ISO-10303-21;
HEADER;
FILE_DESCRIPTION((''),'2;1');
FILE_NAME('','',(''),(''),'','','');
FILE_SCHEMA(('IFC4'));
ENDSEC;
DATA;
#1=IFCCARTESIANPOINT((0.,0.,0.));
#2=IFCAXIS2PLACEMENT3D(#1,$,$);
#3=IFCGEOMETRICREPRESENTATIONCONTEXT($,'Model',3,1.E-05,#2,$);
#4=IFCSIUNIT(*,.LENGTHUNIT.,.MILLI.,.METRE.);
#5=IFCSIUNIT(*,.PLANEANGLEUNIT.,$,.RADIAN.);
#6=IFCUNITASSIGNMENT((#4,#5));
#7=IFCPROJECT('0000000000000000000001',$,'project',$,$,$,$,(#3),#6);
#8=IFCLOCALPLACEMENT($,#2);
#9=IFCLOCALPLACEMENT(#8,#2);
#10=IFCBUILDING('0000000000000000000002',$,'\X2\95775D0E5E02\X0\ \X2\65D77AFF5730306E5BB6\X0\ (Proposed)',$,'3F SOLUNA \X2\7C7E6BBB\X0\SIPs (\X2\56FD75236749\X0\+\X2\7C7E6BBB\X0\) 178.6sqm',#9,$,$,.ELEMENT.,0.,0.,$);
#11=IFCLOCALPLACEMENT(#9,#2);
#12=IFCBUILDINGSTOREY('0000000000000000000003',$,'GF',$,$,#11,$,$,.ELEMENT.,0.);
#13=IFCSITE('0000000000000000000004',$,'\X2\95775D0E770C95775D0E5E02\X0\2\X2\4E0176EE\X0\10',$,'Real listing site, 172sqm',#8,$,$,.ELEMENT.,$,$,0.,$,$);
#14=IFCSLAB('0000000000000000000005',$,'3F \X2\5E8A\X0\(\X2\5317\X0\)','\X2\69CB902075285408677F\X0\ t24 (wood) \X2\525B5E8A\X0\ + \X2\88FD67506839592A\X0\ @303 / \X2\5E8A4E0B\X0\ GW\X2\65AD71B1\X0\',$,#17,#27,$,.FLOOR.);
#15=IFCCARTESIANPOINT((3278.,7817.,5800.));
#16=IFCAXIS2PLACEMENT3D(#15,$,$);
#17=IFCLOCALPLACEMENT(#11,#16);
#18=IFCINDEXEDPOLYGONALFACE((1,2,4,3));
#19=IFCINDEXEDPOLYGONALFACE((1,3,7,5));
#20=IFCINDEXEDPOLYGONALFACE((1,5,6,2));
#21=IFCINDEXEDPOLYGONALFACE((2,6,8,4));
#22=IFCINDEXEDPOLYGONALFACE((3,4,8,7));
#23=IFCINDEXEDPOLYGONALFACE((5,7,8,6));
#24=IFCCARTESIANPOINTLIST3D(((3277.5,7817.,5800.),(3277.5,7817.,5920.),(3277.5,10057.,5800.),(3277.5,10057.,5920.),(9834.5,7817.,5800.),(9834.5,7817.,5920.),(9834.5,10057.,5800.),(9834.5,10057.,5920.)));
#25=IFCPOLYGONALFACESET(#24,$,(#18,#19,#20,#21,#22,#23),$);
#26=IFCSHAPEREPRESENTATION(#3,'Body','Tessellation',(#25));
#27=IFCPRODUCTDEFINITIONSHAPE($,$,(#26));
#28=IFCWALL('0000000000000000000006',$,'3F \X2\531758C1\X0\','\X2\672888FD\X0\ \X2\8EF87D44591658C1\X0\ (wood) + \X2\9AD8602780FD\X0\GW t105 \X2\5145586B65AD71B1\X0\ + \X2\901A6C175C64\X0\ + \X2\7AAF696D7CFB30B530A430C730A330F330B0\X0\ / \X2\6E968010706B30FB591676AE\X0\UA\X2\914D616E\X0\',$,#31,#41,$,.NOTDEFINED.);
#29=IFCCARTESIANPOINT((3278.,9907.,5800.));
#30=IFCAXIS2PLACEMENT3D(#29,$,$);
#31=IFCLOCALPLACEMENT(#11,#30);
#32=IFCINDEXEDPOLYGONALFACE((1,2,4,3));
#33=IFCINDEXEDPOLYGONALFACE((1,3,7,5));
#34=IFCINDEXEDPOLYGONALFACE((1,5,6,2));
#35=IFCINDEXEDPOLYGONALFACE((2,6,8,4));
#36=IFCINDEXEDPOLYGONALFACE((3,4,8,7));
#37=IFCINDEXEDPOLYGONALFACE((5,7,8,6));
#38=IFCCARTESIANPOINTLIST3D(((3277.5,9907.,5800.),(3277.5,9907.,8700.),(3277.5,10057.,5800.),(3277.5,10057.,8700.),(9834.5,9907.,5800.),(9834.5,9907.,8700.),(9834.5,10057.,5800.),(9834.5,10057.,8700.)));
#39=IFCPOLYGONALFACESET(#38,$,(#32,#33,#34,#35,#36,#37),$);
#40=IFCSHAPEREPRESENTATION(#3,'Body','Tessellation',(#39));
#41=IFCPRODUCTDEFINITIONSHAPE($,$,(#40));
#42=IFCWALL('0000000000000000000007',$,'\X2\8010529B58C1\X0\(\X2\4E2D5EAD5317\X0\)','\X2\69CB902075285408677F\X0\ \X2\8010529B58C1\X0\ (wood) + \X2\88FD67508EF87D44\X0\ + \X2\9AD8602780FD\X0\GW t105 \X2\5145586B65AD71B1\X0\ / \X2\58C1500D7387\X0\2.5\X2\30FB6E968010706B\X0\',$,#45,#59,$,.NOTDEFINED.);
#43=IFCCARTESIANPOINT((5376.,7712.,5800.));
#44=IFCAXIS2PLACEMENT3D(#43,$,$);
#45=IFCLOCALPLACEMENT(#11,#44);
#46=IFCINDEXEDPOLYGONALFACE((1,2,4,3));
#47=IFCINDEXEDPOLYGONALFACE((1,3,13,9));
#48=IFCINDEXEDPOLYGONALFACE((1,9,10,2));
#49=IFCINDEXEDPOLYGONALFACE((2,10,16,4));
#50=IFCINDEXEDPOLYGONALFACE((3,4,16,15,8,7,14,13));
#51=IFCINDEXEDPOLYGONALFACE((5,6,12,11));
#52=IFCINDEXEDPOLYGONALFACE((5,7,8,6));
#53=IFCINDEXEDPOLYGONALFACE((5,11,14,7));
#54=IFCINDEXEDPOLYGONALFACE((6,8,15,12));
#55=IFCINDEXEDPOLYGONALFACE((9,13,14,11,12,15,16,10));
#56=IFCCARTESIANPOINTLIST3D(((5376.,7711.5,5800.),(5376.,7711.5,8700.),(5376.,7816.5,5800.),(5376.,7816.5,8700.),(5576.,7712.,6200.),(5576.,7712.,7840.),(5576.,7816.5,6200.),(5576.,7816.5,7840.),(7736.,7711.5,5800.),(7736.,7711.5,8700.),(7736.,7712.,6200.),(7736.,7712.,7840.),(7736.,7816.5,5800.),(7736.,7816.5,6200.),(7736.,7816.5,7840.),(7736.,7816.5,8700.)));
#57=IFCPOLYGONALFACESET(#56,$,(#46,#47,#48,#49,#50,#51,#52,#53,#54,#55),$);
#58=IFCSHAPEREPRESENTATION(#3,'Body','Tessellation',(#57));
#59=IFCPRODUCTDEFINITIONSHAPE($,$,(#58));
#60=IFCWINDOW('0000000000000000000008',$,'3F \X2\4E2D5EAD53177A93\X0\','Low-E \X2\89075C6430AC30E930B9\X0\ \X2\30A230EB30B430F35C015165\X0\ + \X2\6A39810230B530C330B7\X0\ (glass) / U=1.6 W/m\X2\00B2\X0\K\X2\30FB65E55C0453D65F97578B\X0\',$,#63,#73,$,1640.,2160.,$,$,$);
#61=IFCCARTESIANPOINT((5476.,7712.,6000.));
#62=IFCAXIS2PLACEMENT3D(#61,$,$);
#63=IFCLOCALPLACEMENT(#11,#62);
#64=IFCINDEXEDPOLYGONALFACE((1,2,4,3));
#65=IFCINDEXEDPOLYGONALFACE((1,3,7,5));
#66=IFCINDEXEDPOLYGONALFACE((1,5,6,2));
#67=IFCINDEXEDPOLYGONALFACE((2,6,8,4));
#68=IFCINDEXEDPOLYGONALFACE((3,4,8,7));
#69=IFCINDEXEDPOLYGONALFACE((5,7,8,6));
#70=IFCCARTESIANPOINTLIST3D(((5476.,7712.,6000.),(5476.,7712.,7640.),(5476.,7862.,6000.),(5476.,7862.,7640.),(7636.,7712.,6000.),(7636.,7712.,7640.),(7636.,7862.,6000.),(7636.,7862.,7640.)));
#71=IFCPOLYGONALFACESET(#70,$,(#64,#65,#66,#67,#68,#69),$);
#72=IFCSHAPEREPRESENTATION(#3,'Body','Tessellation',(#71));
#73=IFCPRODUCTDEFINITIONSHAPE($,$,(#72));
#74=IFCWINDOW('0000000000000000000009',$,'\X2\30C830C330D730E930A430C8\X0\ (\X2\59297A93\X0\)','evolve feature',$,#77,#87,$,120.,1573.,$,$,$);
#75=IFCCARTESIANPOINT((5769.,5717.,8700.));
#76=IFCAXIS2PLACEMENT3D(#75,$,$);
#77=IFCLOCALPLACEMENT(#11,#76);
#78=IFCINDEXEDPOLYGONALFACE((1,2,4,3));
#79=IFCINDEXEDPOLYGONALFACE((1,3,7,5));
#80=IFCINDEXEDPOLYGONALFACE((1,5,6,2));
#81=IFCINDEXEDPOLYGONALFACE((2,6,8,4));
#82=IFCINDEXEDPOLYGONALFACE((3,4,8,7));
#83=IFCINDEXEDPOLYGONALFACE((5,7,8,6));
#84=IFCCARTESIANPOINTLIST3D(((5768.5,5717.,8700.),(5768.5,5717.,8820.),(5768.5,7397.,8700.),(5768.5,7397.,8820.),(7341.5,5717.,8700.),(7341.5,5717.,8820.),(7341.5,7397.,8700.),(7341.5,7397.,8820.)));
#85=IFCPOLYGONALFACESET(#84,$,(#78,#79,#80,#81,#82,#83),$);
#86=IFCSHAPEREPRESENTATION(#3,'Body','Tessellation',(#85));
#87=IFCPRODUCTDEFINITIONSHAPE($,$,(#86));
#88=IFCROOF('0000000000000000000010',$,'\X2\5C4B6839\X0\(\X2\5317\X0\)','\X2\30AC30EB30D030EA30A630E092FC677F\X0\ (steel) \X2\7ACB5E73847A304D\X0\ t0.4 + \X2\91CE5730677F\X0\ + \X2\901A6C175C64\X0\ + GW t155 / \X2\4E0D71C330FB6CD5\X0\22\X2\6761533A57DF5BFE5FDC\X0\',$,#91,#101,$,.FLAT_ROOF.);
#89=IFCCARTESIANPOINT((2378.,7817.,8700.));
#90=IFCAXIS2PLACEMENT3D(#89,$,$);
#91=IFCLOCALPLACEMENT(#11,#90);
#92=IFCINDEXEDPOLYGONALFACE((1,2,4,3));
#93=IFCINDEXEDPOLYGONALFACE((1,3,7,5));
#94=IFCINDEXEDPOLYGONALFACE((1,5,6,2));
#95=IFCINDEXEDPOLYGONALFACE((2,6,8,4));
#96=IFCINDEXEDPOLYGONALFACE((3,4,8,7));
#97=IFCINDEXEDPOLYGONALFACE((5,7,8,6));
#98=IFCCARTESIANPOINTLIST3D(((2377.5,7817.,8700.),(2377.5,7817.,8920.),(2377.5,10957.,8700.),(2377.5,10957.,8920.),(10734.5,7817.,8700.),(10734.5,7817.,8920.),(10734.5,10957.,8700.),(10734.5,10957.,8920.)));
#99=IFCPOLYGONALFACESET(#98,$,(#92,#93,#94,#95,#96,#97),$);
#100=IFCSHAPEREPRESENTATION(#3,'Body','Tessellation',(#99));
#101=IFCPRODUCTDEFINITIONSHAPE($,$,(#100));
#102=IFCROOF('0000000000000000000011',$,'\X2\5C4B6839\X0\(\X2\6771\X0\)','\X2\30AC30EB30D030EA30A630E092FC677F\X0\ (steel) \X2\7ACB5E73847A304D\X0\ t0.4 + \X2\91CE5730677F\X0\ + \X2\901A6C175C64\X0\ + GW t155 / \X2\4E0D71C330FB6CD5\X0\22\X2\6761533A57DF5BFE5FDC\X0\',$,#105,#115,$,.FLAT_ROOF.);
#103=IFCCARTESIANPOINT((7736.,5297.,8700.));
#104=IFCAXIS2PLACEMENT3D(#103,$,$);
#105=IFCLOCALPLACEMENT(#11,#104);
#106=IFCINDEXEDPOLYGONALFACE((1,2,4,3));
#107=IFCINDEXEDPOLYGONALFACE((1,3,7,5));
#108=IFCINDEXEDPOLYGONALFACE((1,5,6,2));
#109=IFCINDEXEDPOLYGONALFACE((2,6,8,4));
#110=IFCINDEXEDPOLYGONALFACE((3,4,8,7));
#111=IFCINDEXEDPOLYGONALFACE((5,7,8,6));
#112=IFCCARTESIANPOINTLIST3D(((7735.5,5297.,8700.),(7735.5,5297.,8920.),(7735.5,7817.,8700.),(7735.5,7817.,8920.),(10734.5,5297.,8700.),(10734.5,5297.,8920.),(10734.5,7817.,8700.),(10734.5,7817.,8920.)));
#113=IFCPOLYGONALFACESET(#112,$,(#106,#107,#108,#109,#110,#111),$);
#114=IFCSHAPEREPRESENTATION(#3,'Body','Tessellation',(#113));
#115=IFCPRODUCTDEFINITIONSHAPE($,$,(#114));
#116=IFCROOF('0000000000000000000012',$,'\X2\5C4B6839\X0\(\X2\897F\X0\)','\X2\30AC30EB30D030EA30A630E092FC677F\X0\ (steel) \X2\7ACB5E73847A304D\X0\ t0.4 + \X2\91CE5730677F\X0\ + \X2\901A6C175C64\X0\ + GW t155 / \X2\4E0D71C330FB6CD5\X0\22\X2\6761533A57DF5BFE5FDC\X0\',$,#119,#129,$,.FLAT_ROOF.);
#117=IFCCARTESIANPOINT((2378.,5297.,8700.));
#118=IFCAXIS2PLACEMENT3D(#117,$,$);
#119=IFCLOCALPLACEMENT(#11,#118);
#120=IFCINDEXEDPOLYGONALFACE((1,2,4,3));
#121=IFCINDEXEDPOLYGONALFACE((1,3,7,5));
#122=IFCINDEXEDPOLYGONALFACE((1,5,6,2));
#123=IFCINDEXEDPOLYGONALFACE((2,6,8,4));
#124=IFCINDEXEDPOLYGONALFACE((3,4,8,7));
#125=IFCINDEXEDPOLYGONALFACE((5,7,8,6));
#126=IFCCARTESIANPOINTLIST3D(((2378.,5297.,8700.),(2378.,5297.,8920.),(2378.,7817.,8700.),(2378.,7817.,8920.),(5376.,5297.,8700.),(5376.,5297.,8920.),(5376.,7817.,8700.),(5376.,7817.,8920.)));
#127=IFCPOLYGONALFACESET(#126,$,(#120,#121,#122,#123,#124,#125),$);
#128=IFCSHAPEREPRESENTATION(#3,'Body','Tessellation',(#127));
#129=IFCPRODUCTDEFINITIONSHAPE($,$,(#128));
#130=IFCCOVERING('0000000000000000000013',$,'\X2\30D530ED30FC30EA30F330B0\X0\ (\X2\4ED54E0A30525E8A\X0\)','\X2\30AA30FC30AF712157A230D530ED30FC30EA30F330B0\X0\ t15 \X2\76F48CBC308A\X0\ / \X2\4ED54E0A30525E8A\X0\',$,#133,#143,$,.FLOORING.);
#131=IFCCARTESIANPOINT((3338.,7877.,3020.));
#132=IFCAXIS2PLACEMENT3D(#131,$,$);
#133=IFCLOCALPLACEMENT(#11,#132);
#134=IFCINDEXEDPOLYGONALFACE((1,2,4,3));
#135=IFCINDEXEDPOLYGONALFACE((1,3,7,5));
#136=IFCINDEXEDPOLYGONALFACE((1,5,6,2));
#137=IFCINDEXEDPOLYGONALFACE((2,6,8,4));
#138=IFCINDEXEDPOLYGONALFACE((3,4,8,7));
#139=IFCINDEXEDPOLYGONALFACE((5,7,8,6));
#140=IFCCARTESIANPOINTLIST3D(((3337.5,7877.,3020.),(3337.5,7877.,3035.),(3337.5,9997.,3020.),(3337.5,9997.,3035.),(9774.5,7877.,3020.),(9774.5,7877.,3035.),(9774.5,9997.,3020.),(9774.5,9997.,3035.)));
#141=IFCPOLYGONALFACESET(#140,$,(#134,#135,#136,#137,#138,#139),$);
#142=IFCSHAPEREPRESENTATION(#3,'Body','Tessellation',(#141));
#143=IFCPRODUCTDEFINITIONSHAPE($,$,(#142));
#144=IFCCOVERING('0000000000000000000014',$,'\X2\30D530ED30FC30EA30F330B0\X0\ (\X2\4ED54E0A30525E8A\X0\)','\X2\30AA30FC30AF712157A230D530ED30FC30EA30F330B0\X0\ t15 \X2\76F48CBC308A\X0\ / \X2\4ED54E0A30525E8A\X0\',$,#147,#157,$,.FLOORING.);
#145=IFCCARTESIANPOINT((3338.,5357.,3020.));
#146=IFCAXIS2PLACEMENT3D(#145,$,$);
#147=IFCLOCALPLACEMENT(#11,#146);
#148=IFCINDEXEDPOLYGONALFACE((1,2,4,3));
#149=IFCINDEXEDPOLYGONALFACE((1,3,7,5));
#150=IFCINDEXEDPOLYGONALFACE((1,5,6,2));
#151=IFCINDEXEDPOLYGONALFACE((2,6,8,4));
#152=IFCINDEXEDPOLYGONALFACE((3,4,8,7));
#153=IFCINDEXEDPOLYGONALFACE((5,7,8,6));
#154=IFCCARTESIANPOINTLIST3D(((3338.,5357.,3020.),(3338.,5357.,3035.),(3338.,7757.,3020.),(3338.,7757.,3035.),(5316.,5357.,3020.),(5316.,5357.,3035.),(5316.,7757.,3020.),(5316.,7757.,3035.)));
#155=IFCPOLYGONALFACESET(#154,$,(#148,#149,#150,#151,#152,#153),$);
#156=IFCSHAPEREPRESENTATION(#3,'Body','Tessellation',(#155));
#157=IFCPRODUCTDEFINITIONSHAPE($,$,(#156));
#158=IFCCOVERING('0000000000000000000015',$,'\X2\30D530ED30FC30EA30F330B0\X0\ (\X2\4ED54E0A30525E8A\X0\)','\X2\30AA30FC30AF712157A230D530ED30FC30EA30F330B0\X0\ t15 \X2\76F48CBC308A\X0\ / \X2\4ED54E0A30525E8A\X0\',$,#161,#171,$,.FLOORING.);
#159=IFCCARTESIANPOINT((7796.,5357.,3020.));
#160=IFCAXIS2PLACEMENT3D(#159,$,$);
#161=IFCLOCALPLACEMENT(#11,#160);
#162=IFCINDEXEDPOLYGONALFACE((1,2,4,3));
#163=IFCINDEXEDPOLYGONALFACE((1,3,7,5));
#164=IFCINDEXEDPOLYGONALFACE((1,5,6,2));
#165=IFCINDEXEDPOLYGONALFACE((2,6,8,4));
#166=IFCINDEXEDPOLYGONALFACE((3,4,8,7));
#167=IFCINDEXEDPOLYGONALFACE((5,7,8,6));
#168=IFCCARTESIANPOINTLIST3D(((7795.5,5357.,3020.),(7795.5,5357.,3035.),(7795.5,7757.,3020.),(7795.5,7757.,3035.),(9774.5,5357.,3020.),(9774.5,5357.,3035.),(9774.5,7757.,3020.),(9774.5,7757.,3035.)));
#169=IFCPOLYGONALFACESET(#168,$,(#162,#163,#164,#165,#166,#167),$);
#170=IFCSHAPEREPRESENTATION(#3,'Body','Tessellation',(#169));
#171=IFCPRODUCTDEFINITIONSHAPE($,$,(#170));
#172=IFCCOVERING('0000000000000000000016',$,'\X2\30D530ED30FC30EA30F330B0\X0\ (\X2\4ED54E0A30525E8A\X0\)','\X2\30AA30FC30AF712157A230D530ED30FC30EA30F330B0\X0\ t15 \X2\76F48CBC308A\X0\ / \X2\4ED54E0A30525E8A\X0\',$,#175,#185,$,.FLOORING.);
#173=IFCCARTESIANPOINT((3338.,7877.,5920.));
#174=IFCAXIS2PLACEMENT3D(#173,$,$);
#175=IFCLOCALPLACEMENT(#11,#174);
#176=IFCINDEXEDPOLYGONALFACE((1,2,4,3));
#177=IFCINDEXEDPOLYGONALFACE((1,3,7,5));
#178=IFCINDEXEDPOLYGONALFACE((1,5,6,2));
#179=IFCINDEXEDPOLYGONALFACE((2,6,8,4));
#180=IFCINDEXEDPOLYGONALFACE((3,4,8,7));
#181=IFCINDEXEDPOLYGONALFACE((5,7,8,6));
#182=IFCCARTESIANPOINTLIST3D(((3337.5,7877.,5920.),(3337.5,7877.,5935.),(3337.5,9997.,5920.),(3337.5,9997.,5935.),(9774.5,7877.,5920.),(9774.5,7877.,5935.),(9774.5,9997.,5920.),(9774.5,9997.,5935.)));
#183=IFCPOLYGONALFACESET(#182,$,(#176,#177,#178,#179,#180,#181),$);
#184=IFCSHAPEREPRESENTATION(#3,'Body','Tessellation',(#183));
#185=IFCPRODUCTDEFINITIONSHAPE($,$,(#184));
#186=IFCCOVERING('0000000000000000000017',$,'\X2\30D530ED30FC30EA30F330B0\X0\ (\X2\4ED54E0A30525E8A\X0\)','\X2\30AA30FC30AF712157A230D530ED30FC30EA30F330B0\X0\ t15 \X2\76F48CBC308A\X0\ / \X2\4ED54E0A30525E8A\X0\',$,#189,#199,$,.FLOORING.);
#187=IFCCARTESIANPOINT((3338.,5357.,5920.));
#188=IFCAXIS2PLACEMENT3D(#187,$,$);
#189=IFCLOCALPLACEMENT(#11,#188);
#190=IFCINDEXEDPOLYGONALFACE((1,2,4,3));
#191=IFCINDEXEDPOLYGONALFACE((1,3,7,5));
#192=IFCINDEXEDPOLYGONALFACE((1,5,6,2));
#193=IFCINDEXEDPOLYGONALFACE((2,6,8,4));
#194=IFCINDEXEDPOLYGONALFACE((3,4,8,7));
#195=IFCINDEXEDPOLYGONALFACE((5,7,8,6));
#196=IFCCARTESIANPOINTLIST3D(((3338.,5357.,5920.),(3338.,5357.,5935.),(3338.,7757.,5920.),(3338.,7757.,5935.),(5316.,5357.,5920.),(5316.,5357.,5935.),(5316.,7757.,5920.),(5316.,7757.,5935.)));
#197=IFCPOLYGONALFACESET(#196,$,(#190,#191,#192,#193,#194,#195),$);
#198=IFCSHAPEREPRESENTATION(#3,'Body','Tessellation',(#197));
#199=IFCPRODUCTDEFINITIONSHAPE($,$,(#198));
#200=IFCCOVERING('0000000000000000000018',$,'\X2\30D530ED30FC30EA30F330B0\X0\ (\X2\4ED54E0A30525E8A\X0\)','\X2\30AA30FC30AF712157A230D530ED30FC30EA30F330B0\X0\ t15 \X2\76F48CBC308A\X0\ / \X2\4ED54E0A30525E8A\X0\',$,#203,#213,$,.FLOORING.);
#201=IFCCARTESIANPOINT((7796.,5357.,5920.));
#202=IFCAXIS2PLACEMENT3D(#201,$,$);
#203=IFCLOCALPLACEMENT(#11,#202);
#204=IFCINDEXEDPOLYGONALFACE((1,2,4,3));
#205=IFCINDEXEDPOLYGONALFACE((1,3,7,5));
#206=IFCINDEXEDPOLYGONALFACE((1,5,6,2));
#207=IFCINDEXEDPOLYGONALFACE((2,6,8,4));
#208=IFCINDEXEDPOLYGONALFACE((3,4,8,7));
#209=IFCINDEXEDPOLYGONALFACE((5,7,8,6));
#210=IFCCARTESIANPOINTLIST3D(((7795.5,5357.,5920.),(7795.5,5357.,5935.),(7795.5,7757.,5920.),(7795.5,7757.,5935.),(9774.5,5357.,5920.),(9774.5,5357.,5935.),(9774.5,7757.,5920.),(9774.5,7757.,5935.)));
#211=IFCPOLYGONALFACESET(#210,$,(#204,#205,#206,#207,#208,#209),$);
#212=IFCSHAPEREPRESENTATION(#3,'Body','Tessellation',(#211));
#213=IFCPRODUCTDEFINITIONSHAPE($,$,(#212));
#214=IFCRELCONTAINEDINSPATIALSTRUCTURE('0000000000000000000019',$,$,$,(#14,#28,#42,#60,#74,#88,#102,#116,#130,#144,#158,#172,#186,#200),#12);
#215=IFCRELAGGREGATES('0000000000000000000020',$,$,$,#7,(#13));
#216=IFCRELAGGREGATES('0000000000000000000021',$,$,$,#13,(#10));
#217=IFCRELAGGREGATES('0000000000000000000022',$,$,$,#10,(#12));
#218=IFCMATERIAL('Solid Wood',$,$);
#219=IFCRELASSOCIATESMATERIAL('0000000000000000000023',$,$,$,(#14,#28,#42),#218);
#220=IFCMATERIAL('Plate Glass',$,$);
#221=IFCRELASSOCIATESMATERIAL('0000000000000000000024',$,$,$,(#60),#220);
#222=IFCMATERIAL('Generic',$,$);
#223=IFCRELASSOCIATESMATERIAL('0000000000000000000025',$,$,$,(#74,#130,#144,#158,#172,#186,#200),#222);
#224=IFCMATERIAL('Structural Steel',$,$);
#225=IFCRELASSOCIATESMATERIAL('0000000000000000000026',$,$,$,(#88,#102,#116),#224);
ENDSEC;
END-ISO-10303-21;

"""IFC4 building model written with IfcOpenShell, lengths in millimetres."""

from ifc_helpers import new_model, si_unit, frame, frame_2d, origin, place, context, project, spatial, rectangle, extrude, material, element, fill, save


model = new_model("IFC4")

# Units and contexts
model_context = context("Model", 3, precision=1e-05, world=origin())
ifc_project = project(units=[si_unit("LENGTHUNIT", "METRE", prefix="MILLI"), si_unit("PLANEANGLEUNIT", "RADIAN")], contexts=[model_context])

# Site, building, storey
site_placement = place(None, origin())
site = spatial("IfcSite", under=ifc_project, at=site_placement, Name="長崎県長崎市2丁目10", ObjectType="Real listing site, 172sqm", CompositionType="ELEMENT", RefElevation=0.0)
building_placement = place(site_placement, origin())
building = spatial("IfcBuilding", under=site, at=building_placement, Name="長崎市 旗竿地の家 (Proposed)", ObjectType="3F SOLUNA 籾殻SIPs (国産杉+籾殻) 178.6sqm", CompositionType="ELEMENT", ElevationOfRefHeight=0.0, ElevationOfTerrain=0.0)
storey_placement = place(building_placement, origin())
storey = spatial("IfcBuildingStorey", under=building, at=storey_placement, Name="GF", CompositionType="ELEMENT", Elevation=0.0)

# Slab
ifc_material_1 = material(Name="Solid Wood")
slab_placement = place(storey_placement, frame((3278.0, 7817.0, 5800.0)))
element("IfcSlab", 1, at=slab_placement, inside=storey, material=ifc_material_1, Name="3F 床(北)", Description="構造用合板 t24 (wood) 剛床 + 製材根太 @303 / 床下 GW断熱", PredefinedType="FLOOR", context=model_context, shape_type="SweptSolid", body=[
    extrude(rectangle(XDim=6557.0, YDim=2240.0, at=frame_2d((3278.0, 1120.0))), frame((3278.0, 7817.0, 5800.0)), (0.0, 0.0, 1.0), 120.0),
])

# Wall
wall_1_placement = place(storey_placement, frame((3278.0, 9907.0, 5800.0)))
element("IfcWall", 2, at=wall_1_placement, inside=storey, material=ifc_material_1, Name="3F 北壁", Description="木製 軸組外壁 (wood) + 高性能GW t105 充填断熱 + 通気層 + 窯業系サイディング / 準耐火・外皮UA配慮", PredefinedType="NOTDEFINED", context=model_context, shape_type="SweptSolid", body=[
    extrude(rectangle(XDim=6557.0, YDim=150.0, at=frame_2d((3278.0, 75.0))), frame((3278.0, 9907.0, 5800.0)), (0.0, 0.0, 1.0), 2900.0),
])

# Wall, opening, window
wall_2_placement = place(storey_placement, frame((5376.0, 7712.0, 5800.0)))
wall_2 = element("IfcWall", 3, at=wall_2_placement, inside=storey, material=ifc_material_1, Name="耐力壁(中庭北)", Description="構造用合板 耐力壁 (wood) + 製材軸組 + 高性能GW t105 充填断熱 / 壁倍率2.5・準耐火", PredefinedType="NOTDEFINED", context=model_context, shape_type="SweptSolid", body=[
    extrude(rectangle(XDim=2360.0, YDim=105.0, at=frame_2d((1180.0, 52.0))), frame((5376.0, 7712.0, 5800.0)), (0.0, 0.0, 1.0), 2900.0),
])
opening_placement = place(storey_placement, frame((5476.0, 7712.0, 6000.0)))
opening = element("IfcOpeningElement", 4, at=opening_placement, cuts=wall_2, PredefinedType="NOTDEFINED", context=model_context, shape_type="SweptSolid", body=[
    extrude(rectangle(XDim=2160.0, YDim=150.0, at=frame_2d((1080.0, 75.0))), frame((5476.0, 7712.0, 6000.0)), (0.0, 0.0, 1.0), 1640.0),
])
ifc_material_2 = material(Name="Plate Glass")
window_1_placement = place(storey_placement, frame((5476.0, 7712.0, 6000.0)))
window_1 = element("IfcWindow", 5, at=window_1_placement, inside=storey, material=ifc_material_2, Name="3F 中庭北窓", Description="Low-E 複層ガラス アルゴン封入 + 樹脂サッシ (glass) / U=1.6 W/m²K・日射取得型", OverallHeight=1640.0, OverallWidth=2160.0, context=model_context, shape_type="SweptSolid", body=[
    extrude(rectangle(XDim=2160.0, YDim=150.0, at=frame_2d((1080.0, 75.0))), frame((5476.0, 7712.0, 6000.0)), (0.0, 0.0, 1.0), 1640.0),
])
fill(opening, window_1)

# Window
ifc_material_3 = material(Name="Generic")
window_2_placement = place(storey_placement, frame((5769.0, 5717.0, 8700.0)))
element("IfcWindow", 6, at=window_2_placement, inside=storey, material=ifc_material_3, Name="トップライト (天窓)", Description="evolve feature", OverallHeight=120.0, OverallWidth=1573.0, context=model_context, shape_type="SweptSolid", body=[
    extrude(rectangle(XDim=1573.0, YDim=1680.0, at=frame_2d((786.0, 840.0))), frame((5769.0, 5717.0, 8700.0)), (0.0, 0.0, 1.0), 120.0),
])

# Roofs
ifc_material_4 = material(Name="Structural Steel")
roof_1_placement = place(storey_placement, frame((2378.0, 7817.0, 8700.0)))
element("IfcRoof", 7, at=roof_1_placement, inside=storey, material=ifc_material_4, Name="屋根(北)", Description="ガルバリウム鋼板 (steel) 立平葺き t0.4 + 野地板 + 通気層 + GW t155 / 不燃・法22条区域対応", PredefinedType="FLAT_ROOF", context=model_context, shape_type="SweptSolid", body=[
    extrude(rectangle(XDim=8357.0, YDim=3140.0, at=frame_2d((4178.0, 1570.0))), frame((2378.0, 7817.0, 8700.0)), (0.0, 0.0, 1.0), 220.0),
])
roof_2_placement = place(storey_placement, frame((7736.0, 5297.0, 8700.0)))
element("IfcRoof", 8, at=roof_2_placement, inside=storey, material=ifc_material_4, Name="屋根(東)", Description="ガルバリウム鋼板 (steel) 立平葺き t0.4 + 野地板 + 通気層 + GW t155 / 不燃・法22条区域対応", PredefinedType="FLAT_ROOF", context=model_context, shape_type="SweptSolid", body=[
    extrude(rectangle(XDim=2999.0, YDim=2520.0, at=frame_2d((1499.0, 1260.0))), frame((7736.0, 5297.0, 8700.0)), (0.0, 0.0, 1.0), 220.0),
])
roof_3_placement = place(storey_placement, frame((2378.0, 5297.0, 8700.0)))
element("IfcRoof", 9, at=roof_3_placement, inside=storey, material=ifc_material_4, Name="屋根(西)", Description="ガルバリウム鋼板 (steel) 立平葺き t0.4 + 野地板 + 通気層 + GW t155 / 不燃・法22条区域対応", PredefinedType="FLAT_ROOF", context=model_context, shape_type="SweptSolid", body=[
    extrude(rectangle(XDim=2998.0, YDim=2520.0, at=frame_2d((1499.0, 1260.0))), frame((2378.0, 5297.0, 8700.0)), (0.0, 0.0, 1.0), 220.0),
])

# Coverings
covering_1_placement = place(storey_placement, frame((3338.0, 7877.0, 3020.0)))
element("IfcCovering", 10, at=covering_1_placement, inside=storey, material=ifc_material_3, Name="フローリング (仕上げ床)", Description="オーク無垢フローリング t15 直貼り / 仕上げ床", PredefinedType="FLOORING", context=model_context, shape_type="SweptSolid", body=[
    extrude(rectangle(XDim=6437.0, YDim=2120.0, at=frame_2d((3218.0, 1060.0))), frame((3338.0, 7877.0, 3020.0)), (0.0, 0.0, 1.0), 15.0),
])
covering_2_placement = place(storey_placement, frame((3338.0, 5357.0, 3020.0)))
element("IfcCovering", 11, at=covering_2_placement, inside=storey, material=ifc_material_3, Name="フローリング (仕上げ床)", Description="オーク無垢フローリング t15 直貼り / 仕上げ床", PredefinedType="FLOORING", context=model_context, shape_type="SweptSolid", body=[
    extrude(rectangle(XDim=1978.0, YDim=2400.0, at=frame_2d((989.0, 1200.0))), frame((3338.0, 5357.0, 3020.0)), (0.0, 0.0, 1.0), 15.0),
])
covering_3_placement = place(storey_placement, frame((7796.0, 5357.0, 3020.0)))
element("IfcCovering", 12, at=covering_3_placement, inside=storey, material=ifc_material_3, Name="フローリング (仕上げ床)", Description="オーク無垢フローリング t15 直貼り / 仕上げ床", PredefinedType="FLOORING", context=model_context, shape_type="SweptSolid", body=[
    extrude(rectangle(XDim=1979.0, YDim=2400.0, at=frame_2d((989.0, 1200.0))), frame((7796.0, 5357.0, 3020.0)), (0.0, 0.0, 1.0), 15.0),
])
covering_4_placement = place(storey_placement, frame((3338.0, 7877.0, 5920.0)))
element("IfcCovering", 13, at=covering_4_placement, inside=storey, material=ifc_material_3, Name="フローリング (仕上げ床)", Description="オーク無垢フローリング t15 直貼り / 仕上げ床", PredefinedType="FLOORING", context=model_context, shape_type="SweptSolid", body=[
    extrude(rectangle(XDim=6437.0, YDim=2120.0, at=frame_2d((3218.0, 1060.0))), frame((3338.0, 7877.0, 5920.0)), (0.0, 0.0, 1.0), 15.0),
])
covering_5_placement = place(storey_placement, frame((3338.0, 5357.0, 5920.0)))
element("IfcCovering", 14, at=covering_5_placement, inside=storey, material=ifc_material_3, Name="フローリング (仕上げ床)", Description="オーク無垢フローリング t15 直貼り / 仕上げ床", PredefinedType="FLOORING", context=model_context, shape_type="SweptSolid", body=[
    extrude(rectangle(XDim=1978.0, YDim=2400.0, at=frame_2d((989.0, 1200.0))), frame((3338.0, 5357.0, 5920.0)), (0.0, 0.0, 1.0), 15.0),
])
covering_6_placement = place(storey_placement, frame((7796.0, 5357.0, 5920.0)))
element("IfcCovering", 15, at=covering_6_placement, inside=storey, material=ifc_material_3, Name="フローリング (仕上げ床)", Description="オーク無垢フローリング t15 直貼り / 仕上げ床", PredefinedType="FLOORING", context=model_context, shape_type="SweptSolid", body=[
    extrude(rectangle(XDim=1979.0, YDim=2400.0, at=frame_2d((989.0, 1200.0))), frame((7796.0, 5357.0, 5920.0)), (0.0, 0.0, 1.0), 15.0),
])

save(model, "model.ifc")
